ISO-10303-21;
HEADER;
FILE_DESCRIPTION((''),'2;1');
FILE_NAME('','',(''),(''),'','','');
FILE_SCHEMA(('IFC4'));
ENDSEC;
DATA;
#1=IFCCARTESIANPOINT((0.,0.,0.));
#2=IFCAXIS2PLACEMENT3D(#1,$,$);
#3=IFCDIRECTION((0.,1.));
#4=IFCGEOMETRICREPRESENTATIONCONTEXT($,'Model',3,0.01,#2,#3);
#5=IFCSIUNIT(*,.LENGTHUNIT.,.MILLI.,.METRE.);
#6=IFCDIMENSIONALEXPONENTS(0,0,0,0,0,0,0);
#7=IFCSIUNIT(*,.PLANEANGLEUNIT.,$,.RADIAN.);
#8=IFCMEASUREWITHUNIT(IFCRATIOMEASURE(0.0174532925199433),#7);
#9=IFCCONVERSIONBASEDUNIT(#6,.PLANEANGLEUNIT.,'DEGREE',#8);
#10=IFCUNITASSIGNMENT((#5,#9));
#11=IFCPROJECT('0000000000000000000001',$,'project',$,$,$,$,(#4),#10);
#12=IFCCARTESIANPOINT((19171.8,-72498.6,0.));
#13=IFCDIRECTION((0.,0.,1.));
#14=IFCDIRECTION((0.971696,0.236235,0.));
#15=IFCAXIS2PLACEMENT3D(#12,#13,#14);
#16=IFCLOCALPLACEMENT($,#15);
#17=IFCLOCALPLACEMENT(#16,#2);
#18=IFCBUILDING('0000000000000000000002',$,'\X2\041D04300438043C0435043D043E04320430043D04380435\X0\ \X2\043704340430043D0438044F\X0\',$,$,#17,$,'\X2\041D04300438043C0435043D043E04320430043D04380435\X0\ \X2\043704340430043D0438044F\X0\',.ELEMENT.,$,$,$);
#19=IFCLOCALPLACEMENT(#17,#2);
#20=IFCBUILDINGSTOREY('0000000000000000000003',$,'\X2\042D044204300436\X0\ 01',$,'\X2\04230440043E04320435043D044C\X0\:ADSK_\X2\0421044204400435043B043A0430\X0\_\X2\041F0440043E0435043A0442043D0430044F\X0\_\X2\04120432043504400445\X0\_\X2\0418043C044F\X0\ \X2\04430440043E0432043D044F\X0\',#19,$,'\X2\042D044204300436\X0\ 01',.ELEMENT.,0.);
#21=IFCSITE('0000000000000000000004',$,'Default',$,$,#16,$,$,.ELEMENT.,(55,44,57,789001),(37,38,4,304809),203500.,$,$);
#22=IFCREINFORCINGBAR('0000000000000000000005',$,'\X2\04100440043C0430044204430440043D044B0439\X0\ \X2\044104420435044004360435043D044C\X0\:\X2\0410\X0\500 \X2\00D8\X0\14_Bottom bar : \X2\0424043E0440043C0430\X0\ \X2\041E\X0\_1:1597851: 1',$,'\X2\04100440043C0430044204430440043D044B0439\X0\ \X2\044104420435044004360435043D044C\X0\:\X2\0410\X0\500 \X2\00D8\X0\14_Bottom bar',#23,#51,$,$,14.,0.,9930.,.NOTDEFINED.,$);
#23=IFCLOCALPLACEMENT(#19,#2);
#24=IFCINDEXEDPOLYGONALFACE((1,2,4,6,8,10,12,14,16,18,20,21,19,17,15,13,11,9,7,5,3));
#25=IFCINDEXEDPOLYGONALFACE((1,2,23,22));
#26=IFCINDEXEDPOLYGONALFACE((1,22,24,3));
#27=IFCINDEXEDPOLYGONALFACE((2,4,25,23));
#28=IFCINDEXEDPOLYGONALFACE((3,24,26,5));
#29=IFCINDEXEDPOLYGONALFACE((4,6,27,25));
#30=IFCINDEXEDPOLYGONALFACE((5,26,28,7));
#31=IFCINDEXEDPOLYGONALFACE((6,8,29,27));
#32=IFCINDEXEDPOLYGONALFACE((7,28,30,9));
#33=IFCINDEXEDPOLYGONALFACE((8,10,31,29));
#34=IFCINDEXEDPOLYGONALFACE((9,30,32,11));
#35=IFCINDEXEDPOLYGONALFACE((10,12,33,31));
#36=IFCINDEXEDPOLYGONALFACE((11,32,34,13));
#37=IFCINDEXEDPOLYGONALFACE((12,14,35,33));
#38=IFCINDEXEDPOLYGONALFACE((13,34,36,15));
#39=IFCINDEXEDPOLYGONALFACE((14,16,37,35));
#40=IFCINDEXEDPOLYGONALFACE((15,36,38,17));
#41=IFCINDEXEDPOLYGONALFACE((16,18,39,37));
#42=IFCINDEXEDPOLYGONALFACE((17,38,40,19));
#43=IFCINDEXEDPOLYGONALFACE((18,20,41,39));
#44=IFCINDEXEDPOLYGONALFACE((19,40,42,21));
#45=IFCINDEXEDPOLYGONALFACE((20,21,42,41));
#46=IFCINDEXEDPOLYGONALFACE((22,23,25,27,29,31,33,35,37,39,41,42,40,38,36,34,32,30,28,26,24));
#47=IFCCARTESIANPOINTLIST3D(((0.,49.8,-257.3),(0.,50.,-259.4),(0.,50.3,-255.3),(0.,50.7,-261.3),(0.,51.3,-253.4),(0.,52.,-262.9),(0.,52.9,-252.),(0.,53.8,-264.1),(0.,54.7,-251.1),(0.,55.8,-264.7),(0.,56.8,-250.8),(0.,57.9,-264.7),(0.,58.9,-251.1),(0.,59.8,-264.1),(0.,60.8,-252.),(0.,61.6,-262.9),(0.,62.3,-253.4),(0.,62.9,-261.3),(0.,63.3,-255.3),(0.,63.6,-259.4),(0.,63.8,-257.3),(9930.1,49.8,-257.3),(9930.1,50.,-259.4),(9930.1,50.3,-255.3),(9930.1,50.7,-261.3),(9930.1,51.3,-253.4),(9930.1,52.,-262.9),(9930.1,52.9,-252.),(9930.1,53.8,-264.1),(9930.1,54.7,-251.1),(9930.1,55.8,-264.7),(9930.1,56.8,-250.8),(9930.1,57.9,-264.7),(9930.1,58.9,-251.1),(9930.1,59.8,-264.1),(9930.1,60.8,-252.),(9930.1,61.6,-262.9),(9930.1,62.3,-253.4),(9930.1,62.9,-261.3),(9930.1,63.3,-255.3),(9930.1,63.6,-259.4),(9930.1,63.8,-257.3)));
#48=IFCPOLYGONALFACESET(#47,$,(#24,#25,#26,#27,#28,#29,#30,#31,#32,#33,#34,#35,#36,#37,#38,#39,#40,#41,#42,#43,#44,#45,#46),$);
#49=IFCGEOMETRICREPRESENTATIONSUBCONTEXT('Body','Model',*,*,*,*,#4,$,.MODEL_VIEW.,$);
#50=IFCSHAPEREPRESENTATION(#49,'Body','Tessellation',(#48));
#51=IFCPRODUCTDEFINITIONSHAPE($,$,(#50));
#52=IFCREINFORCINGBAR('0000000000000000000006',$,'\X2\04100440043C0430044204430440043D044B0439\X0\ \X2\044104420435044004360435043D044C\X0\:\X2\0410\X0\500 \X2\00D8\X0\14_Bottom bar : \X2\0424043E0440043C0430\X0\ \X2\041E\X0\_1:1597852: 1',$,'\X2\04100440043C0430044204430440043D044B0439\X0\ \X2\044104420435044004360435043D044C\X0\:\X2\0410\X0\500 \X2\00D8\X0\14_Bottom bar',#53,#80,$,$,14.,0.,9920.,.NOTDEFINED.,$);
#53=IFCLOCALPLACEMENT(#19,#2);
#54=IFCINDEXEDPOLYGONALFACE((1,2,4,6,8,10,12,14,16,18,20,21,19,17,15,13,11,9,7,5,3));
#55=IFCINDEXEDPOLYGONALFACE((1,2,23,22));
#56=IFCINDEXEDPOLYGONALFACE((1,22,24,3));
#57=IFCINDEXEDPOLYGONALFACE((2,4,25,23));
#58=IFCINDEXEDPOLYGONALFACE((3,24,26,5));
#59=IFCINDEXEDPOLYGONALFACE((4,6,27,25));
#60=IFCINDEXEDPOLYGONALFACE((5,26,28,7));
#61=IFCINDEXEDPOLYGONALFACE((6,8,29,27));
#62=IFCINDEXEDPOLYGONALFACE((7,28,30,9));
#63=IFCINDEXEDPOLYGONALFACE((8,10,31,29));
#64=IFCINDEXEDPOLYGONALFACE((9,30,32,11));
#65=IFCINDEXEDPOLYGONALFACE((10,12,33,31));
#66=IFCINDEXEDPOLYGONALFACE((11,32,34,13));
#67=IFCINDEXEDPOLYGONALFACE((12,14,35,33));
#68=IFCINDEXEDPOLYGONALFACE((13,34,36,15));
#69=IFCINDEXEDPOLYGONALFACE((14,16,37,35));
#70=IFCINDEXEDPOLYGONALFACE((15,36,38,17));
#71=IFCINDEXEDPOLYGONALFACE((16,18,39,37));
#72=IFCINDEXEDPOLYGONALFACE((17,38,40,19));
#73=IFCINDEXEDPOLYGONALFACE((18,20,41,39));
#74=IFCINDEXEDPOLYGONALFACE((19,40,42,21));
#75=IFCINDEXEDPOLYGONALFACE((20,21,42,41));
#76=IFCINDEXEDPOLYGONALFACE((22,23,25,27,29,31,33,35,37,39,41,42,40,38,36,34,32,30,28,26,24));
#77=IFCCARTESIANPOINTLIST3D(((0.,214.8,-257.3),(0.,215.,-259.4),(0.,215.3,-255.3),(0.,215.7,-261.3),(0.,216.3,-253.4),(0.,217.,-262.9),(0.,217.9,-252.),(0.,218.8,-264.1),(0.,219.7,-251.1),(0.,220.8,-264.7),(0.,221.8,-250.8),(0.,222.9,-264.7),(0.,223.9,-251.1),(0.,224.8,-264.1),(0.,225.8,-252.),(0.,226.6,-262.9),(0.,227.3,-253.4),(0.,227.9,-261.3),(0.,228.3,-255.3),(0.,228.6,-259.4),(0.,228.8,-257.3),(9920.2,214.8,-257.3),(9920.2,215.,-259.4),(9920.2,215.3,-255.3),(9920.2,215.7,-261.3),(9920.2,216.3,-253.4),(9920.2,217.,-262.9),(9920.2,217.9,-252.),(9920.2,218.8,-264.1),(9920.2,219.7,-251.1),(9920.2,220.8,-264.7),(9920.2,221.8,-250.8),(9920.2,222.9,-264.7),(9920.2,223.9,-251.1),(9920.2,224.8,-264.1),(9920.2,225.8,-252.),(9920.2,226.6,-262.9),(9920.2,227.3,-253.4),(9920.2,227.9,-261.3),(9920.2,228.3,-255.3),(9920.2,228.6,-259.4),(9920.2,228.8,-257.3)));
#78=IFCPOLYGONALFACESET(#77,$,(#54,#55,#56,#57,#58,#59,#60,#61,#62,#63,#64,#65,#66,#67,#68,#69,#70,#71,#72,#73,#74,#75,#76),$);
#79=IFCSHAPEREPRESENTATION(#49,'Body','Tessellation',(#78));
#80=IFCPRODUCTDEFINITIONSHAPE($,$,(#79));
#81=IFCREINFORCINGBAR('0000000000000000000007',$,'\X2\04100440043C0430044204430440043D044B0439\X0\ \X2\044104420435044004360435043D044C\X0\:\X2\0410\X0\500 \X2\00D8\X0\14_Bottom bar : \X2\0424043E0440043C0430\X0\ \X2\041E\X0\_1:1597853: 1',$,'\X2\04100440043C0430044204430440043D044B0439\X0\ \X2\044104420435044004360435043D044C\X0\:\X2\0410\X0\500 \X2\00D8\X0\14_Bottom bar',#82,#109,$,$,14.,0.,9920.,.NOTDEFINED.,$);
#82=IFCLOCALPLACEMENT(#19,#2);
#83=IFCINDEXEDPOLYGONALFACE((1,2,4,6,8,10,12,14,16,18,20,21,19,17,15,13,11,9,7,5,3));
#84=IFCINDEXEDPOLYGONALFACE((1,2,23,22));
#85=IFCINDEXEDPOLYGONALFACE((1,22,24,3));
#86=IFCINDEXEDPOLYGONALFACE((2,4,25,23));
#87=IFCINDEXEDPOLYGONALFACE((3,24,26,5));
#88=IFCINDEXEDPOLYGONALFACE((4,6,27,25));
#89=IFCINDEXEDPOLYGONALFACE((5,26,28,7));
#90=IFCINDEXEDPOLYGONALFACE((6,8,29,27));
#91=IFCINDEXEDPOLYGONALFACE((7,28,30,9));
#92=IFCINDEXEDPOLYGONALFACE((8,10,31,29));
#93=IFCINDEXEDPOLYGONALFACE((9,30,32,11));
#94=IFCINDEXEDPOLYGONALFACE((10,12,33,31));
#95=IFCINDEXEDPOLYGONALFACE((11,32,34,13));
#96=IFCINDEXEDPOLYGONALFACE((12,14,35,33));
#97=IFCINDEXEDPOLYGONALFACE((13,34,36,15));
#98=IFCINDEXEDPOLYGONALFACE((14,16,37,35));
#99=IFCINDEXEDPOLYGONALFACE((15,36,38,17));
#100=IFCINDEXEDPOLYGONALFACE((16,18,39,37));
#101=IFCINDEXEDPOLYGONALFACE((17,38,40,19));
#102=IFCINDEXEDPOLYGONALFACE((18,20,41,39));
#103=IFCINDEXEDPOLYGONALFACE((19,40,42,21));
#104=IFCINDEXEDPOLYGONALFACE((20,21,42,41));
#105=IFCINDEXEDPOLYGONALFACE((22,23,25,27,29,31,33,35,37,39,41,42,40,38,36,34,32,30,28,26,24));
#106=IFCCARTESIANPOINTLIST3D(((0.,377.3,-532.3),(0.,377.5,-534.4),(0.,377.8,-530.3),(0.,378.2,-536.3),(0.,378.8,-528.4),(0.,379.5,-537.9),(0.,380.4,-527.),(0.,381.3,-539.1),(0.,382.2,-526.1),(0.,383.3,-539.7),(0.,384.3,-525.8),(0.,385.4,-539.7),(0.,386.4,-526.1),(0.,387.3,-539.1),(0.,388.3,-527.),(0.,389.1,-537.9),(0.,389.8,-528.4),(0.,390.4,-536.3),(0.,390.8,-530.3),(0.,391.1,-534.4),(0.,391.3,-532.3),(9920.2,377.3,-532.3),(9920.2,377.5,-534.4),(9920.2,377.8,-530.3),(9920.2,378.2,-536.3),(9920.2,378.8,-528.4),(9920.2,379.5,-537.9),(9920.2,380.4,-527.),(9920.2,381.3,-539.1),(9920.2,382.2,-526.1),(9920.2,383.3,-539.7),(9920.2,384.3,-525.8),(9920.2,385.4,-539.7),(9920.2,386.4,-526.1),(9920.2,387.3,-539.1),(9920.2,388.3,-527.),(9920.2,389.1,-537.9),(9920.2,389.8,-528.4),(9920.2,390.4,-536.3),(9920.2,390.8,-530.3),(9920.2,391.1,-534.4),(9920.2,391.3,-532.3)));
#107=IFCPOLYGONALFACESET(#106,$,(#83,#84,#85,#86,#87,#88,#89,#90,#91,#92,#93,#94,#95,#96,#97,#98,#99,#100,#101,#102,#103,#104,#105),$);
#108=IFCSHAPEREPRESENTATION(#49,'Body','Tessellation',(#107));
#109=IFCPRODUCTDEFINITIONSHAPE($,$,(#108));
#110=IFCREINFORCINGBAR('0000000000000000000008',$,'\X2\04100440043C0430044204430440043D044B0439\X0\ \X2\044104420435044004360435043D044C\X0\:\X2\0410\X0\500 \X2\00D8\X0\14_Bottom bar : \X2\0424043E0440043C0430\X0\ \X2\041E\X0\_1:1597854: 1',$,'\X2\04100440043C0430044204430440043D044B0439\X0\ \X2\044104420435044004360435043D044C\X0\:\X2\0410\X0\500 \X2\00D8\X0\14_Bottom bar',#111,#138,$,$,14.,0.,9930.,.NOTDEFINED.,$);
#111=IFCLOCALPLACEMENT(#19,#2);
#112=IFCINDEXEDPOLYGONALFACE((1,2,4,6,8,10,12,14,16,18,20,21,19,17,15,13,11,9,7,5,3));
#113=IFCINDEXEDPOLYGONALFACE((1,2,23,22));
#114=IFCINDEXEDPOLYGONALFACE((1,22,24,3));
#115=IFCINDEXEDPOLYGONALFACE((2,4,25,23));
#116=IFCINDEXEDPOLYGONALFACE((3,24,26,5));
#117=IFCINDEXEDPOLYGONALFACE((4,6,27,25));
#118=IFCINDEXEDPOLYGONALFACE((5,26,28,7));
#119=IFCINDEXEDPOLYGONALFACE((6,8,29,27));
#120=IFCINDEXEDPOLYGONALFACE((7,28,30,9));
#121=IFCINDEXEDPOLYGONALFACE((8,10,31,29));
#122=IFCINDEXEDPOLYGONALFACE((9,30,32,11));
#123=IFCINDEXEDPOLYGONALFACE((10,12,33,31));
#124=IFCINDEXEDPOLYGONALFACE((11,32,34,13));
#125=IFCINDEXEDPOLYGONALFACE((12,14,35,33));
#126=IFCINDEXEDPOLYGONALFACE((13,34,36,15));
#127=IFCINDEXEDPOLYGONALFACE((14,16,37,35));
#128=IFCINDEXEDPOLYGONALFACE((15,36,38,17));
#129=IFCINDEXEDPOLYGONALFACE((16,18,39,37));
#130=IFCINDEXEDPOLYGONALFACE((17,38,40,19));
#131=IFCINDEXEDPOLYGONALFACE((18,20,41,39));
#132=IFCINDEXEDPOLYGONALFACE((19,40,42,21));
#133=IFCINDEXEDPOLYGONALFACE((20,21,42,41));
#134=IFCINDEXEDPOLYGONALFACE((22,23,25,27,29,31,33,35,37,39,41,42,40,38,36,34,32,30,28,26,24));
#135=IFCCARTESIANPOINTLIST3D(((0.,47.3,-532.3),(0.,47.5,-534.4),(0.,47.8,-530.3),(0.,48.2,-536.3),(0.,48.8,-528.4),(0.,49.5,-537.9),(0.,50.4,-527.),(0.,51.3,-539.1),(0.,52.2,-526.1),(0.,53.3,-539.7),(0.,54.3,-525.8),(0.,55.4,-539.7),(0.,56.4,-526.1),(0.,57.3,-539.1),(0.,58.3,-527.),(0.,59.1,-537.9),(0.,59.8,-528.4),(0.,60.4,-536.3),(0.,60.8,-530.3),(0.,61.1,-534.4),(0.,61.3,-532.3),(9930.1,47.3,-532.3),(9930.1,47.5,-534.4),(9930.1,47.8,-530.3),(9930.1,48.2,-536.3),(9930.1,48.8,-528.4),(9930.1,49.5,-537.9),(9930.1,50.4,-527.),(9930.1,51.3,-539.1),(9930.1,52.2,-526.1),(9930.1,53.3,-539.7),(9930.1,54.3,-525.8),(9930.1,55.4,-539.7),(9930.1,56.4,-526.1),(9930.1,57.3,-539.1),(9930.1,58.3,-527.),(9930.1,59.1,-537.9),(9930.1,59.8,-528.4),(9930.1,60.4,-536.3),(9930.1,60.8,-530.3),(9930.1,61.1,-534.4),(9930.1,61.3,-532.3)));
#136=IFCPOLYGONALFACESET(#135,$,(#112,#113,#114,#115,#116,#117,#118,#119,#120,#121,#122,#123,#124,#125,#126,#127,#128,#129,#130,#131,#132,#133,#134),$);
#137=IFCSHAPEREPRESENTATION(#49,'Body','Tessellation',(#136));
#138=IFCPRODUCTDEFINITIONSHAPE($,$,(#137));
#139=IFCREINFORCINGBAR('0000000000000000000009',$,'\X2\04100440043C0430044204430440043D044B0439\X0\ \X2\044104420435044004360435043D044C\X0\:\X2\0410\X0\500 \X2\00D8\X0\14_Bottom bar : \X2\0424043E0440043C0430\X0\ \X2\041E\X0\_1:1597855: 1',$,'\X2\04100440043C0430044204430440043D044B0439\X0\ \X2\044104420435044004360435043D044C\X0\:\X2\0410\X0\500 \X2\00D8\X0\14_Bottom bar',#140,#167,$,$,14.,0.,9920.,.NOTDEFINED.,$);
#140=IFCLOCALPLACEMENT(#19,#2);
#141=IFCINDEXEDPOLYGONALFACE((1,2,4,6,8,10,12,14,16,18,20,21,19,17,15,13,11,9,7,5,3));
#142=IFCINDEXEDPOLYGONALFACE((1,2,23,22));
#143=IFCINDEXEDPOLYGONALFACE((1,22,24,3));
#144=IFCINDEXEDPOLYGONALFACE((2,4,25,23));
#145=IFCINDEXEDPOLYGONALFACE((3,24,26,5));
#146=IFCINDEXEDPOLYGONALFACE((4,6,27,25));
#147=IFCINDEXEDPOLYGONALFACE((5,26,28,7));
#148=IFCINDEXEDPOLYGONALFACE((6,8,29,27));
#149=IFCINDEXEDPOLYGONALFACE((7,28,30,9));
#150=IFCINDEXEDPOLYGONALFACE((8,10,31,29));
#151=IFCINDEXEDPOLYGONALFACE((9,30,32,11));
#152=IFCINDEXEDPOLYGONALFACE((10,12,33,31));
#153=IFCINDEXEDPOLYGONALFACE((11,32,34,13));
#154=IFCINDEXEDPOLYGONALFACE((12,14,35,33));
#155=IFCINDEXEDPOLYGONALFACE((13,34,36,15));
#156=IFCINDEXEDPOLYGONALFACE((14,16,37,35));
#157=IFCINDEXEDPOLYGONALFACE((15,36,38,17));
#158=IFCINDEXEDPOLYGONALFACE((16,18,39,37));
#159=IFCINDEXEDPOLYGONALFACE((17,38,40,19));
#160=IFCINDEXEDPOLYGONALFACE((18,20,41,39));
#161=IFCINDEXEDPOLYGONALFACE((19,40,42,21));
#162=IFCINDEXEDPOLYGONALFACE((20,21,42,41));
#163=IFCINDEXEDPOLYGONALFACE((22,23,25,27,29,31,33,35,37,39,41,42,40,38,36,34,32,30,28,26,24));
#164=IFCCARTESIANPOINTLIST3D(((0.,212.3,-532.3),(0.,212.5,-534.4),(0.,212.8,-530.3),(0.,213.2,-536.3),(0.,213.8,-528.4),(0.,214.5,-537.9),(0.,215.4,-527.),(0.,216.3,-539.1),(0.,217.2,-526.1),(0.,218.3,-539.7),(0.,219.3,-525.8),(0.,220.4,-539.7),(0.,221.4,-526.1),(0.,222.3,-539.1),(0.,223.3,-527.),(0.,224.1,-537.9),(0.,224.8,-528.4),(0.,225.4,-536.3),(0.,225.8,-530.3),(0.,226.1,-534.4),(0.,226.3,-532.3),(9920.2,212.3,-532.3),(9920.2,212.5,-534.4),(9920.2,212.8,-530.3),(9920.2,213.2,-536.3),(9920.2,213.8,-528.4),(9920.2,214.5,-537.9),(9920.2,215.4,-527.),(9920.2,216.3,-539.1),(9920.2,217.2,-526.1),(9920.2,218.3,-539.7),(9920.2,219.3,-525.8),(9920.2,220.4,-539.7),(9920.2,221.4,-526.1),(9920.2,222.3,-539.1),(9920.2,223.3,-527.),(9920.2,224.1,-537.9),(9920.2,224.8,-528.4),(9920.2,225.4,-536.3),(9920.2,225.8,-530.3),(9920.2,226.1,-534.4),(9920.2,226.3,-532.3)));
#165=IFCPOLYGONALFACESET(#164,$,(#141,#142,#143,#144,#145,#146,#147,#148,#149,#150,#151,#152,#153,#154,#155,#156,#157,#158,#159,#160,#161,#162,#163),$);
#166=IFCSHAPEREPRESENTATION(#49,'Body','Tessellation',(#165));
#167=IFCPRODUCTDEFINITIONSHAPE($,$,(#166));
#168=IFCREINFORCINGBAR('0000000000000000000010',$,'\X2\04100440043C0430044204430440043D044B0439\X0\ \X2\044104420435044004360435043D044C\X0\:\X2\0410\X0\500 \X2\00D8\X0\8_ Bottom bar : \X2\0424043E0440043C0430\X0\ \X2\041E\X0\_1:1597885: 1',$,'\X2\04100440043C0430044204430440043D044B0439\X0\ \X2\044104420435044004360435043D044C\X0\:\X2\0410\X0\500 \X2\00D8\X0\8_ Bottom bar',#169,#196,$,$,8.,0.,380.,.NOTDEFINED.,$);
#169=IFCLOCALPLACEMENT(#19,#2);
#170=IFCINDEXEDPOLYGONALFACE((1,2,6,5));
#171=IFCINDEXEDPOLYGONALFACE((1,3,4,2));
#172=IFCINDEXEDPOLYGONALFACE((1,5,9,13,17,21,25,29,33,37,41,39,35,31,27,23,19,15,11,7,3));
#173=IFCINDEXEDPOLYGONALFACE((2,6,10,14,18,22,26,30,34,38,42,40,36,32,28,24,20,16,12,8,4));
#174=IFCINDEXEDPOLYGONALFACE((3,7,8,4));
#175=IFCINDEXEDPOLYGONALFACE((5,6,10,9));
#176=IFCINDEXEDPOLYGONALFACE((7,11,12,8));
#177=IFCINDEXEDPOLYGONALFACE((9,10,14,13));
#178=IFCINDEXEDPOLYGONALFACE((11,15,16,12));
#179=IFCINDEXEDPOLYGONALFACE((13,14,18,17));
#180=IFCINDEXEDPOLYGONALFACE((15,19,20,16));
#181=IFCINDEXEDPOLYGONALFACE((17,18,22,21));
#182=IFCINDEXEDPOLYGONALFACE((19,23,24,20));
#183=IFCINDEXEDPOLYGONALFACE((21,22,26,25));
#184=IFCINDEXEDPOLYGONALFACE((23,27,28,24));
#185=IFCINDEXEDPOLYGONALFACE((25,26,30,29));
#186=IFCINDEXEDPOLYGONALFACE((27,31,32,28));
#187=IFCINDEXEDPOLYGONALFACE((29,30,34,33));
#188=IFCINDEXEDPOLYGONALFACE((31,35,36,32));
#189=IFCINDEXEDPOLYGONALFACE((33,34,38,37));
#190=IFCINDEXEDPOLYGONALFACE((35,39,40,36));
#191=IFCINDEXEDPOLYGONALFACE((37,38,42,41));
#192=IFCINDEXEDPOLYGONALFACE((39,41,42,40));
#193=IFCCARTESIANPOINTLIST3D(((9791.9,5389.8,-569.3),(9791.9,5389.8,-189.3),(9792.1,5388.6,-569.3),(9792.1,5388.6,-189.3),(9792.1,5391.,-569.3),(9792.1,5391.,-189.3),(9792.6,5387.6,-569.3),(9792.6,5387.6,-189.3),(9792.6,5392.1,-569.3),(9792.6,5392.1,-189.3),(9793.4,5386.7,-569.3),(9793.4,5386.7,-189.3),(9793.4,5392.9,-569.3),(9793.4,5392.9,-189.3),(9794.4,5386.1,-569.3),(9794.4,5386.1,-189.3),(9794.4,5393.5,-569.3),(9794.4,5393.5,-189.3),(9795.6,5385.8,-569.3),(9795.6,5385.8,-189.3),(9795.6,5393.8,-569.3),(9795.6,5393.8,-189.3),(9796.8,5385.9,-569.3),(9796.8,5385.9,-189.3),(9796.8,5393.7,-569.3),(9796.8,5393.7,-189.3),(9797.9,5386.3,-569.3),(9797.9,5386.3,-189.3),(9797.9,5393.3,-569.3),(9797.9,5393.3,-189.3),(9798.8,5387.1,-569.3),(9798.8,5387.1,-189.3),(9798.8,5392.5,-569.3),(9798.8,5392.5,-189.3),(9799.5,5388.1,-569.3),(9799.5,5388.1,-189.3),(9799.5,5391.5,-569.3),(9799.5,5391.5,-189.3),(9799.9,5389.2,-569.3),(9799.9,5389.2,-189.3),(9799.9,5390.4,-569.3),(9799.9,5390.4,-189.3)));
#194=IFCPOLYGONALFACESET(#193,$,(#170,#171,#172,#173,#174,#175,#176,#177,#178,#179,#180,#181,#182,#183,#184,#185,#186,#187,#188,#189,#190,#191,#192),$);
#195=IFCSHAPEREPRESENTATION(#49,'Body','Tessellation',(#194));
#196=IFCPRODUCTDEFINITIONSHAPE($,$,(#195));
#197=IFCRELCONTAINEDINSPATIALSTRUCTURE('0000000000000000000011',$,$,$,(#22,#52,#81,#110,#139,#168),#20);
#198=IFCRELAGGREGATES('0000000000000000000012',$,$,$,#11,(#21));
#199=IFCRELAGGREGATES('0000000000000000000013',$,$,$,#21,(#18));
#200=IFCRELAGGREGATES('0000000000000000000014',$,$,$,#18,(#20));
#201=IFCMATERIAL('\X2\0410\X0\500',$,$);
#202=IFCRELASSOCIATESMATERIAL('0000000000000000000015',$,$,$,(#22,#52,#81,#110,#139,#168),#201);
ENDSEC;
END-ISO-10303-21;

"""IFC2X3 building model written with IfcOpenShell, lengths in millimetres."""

from ifc_helpers import new_model, entity, si_unit, converted_unit, direction, frame, origin, place, context, subcontext, project, spatial, material, element, save


model = new_model("IFC2X3")

# Units and contexts
model_context = context("Model", 3, precision=0.01, world=origin(), true_north=direction((0.0, 1.0)))
body_context = subcontext(model_context, "Body", "Model", "MODEL_VIEW")
ifc_project = project(units=[si_unit("LENGTHUNIT", "METRE", prefix="MILLI"), converted_unit("PLANEANGLEUNIT", "DEGREE", entity("IfcRatioMeasure", 0.0174532925199433), si_unit("PLANEANGLEUNIT", "RADIAN"), dimensions=[0, 0, 0, 0, 0, 0, 0])], contexts=[model_context])

# Site, building, storey
site_placement = place(None, frame((19171.8, -72498.6, 0.0), z_axis=(0.0, 0.0, 1.0), x_axis=(0.971696, 0.236235, 0.0)))
site = spatial("IfcSite", under=ifc_project, at=site_placement, Name="Default", CompositionType="ELEMENT", RefLatitude=(55, 44, 57, 789001), RefLongitude=(37, 38, 4, 304809), RefElevation=203500.0)
building_placement = place(site_placement, origin())
building = spatial("IfcBuilding", under=site, at=building_placement, Name="Наименование здания", LongName="Наименование здания", CompositionType="ELEMENT")
storey_placement = place(building_placement, origin())
storey = spatial("IfcBuildingStorey", under=building, at=storey_placement, Name="Этаж 01", ObjectType="Уровень:ADSK_Стрелка_Проектная_Вверх_Имя уровня", LongName="Этаж 01", CompositionType="ELEMENT", Elevation=0.0)

# Reinforcing bars
ifc_material = material(Name="А500")
placement = place(storey_placement, origin())
element("IfcReinforcingBar", 1, at=placement, inside=storey, material=ifc_material, Name="Арматурный стержень:А500 Ø14_Bottom bar : Форма О_1:1597851: 1", ObjectType="Арматурный стержень:А500 Ø14_Bottom bar", BarLength=9930.0, BarRole="NOTDEFINED", CrossSectionArea=0.0, NominalDiameter=14.0, context=body_context, shape_type="AdvancedSweptSolid", body=[
    entity("IfcSweptDiskSolid", entity("IfcCompositeCurve", [entity("IfcCompositeCurveSegment", "CONTINUOUS", True, entity("IfcPolyline", [entity("IfcCartesianPoint", [0.0, 56.8, -257.8]), entity("IfcCartesianPoint", [9930.1, 56.8, -257.8])]))], False), 7.0, None, 0.0, 1.0),
])
element("IfcReinforcingBar", 2, at=placement, inside=storey, material=ifc_material, Name="Арматурный стержень:А500 Ø14_Bottom bar : Форма О_1:1597852: 1", ObjectType="Арматурный стержень:А500 Ø14_Bottom bar", BarLength=9920.0, BarRole="NOTDEFINED", CrossSectionArea=0.0, NominalDiameter=14.0, context=body_context, shape_type="AdvancedSweptSolid", body=[
    entity("IfcSweptDiskSolid", entity("IfcCompositeCurve", [entity("IfcCompositeCurveSegment", "CONTINUOUS", True, entity("IfcPolyline", [entity("IfcCartesianPoint", [0.0, 221.8, -257.8]), entity("IfcCartesianPoint", [9920.2, 221.8, -257.8])]))], False), 7.0, None, 0.0, 1.0),
])
element("IfcReinforcingBar", 3, at=placement, inside=storey, material=ifc_material, Name="Арматурный стержень:А500 Ø14_Bottom bar : Форма О_1:1597853: 1", ObjectType="Арматурный стержень:А500 Ø14_Bottom bar", BarLength=9920.0, BarRole="NOTDEFINED", CrossSectionArea=0.0, NominalDiameter=14.0, context=body_context, shape_type="AdvancedSweptSolid", body=[
    entity("IfcSweptDiskSolid", entity("IfcCompositeCurve", [entity("IfcCompositeCurveSegment", "CONTINUOUS", True, entity("IfcPolyline", [entity("IfcCartesianPoint", [0.0, 384.3, -532.8]), entity("IfcCartesianPoint", [9920.2, 384.3, -532.8])]))], False), 7.0, None, 0.0, 1.0),
])
element("IfcReinforcingBar", 4, at=placement, inside=storey, material=ifc_material, Name="Арматурный стержень:А500 Ø14_Bottom bar : Форма О_1:1597854: 1", ObjectType="Арматурный стержень:А500 Ø14_Bottom bar", BarLength=9930.0, BarRole="NOTDEFINED", CrossSectionArea=0.0, NominalDiameter=14.0, context=body_context, shape_type="AdvancedSweptSolid", body=[
    entity("IfcSweptDiskSolid", entity("IfcCompositeCurve", [entity("IfcCompositeCurveSegment", "CONTINUOUS", True, entity("IfcPolyline", [entity("IfcCartesianPoint", [0.0, 54.3, -532.8]), entity("IfcCartesianPoint", [9930.1, 54.3, -532.8])]))], False), 7.0, None, 0.0, 1.0),
])
element("IfcReinforcingBar", 5, at=placement, inside=storey, material=ifc_material, Name="Арматурный стержень:А500 Ø14_Bottom bar : Форма О_1:1597855: 1", ObjectType="Арматурный стержень:А500 Ø14_Bottom bar", BarLength=9920.0, BarRole="NOTDEFINED", CrossSectionArea=0.0, NominalDiameter=14.0, context=body_context, shape_type="AdvancedSweptSolid", body=[
    entity("IfcSweptDiskSolid", entity("IfcCompositeCurve", [entity("IfcCompositeCurveSegment", "CONTINUOUS", True, entity("IfcPolyline", [entity("IfcCartesianPoint", [0.0, 219.3, -532.8]), entity("IfcCartesianPoint", [9920.2, 219.3, -532.8])]))], False), 7.0, None, 0.0, 1.0),
])
element("IfcReinforcingBar", 6, at=placement, inside=storey, material=ifc_material, Name="Арматурный стержень:А500 Ø8_ Bottom bar : Форма О_1:1597885: 1", ObjectType="Арматурный стержень:А500 Ø8_ Bottom bar", BarLength=380.0, BarRole="NOTDEFINED", CrossSectionArea=0.0, NominalDiameter=8.0, context=body_context, shape_type="AdvancedSweptSolid", body=[
    entity("IfcSweptDiskSolid", entity("IfcCompositeCurve", [entity("IfcCompositeCurveSegment", "CONTINUOUS", True, entity("IfcPolyline", [entity("IfcCartesianPoint", [9795.9, 5389.8, -189.3]), entity("IfcCartesianPoint", [9795.9, 5389.8, -569.3])]))], False), 4.0, None, 0.0, 1.0),
])

save(model, "model.ifc")
